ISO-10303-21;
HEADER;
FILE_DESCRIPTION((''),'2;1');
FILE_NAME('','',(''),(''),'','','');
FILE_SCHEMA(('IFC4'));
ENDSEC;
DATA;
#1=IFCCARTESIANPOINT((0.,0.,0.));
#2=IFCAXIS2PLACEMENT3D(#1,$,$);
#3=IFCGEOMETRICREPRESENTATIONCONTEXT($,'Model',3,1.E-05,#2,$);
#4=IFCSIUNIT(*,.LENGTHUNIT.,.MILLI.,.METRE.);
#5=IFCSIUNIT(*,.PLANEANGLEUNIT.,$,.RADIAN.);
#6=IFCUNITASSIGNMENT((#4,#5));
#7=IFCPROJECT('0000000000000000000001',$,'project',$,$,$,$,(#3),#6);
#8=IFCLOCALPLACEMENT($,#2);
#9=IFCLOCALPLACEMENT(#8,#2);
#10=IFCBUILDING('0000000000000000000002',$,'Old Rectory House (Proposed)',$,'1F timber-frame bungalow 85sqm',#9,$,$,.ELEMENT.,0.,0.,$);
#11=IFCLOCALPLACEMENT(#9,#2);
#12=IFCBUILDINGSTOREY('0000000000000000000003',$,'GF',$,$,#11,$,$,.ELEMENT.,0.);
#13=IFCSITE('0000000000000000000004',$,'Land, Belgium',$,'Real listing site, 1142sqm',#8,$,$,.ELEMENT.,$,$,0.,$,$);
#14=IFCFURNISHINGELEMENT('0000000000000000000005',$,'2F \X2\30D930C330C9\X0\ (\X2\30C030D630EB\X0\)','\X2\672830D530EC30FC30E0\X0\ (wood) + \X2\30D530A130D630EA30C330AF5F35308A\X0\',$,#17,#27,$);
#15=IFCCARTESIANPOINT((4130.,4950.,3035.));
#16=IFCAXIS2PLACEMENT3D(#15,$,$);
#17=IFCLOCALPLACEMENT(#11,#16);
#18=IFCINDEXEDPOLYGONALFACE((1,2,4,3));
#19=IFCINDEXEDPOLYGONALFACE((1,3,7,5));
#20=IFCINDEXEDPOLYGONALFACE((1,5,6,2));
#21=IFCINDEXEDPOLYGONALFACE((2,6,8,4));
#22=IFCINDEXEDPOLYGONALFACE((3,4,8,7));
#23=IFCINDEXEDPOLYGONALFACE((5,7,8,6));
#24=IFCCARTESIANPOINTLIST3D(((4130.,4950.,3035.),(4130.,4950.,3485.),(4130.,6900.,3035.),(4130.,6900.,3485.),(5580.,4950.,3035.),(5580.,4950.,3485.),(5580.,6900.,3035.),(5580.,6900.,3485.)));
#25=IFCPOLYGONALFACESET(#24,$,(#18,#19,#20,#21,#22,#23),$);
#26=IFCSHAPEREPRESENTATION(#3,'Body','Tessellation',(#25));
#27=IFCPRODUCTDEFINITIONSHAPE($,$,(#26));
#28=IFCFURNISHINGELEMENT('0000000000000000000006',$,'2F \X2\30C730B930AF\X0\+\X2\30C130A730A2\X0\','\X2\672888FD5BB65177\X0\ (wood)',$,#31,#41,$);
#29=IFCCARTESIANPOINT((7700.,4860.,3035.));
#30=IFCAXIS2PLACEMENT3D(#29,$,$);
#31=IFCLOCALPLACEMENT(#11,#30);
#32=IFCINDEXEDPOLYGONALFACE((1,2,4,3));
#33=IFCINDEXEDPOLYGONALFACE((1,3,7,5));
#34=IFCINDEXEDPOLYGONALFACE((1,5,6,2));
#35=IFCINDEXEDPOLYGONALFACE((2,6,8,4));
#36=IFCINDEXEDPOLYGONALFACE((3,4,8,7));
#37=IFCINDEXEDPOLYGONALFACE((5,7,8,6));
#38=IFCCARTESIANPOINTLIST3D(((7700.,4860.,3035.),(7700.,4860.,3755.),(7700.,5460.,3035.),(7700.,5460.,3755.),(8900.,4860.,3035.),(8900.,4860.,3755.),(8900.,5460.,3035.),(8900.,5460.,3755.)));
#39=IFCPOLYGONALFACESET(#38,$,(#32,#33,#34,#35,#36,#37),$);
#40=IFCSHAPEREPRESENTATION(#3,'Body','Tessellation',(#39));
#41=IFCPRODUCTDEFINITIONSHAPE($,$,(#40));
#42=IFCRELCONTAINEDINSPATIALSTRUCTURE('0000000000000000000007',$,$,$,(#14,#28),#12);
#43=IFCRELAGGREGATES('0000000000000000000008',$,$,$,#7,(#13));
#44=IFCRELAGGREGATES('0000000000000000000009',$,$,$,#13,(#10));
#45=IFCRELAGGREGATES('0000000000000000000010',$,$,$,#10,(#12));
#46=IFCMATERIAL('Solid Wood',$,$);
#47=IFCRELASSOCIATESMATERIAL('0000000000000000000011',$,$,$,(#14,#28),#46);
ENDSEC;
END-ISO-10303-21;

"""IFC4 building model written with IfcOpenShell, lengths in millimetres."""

from ifc_helpers import new_model, si_unit, frame, frame_2d, origin, place, context, project, spatial, rectangle, extrude, material, element, save


model = new_model("IFC4")

# Units and contexts
model_context = context("Model", 3, precision=1e-05, world=origin())
ifc_project = project(units=[si_unit("LENGTHUNIT", "METRE", prefix="MILLI"), si_unit("PLANEANGLEUNIT", "RADIAN")], contexts=[model_context])

# Site, building, storey
site_placement = place(None, origin())
site = spatial("IfcSite", under=ifc_project, at=site_placement, Name="Land, Belgium", ObjectType="Real listing site, 1142sqm", CompositionType="ELEMENT", RefElevation=0.0)
building_placement = place(site_placement, origin())
building = spatial("IfcBuilding", under=site, at=building_placement, Name="Old Rectory House (Proposed)", ObjectType="1F timber-frame bungalow 85sqm", CompositionType="ELEMENT", ElevationOfRefHeight=0.0, ElevationOfTerrain=0.0)
storey_placement = place(building_placement, origin())
storey = spatial("IfcBuildingStorey", under=building, at=storey_placement, Name="GF", CompositionType="ELEMENT", Elevation=0.0)

# Shared definitions
ifc_material_1 = material(Name="Solid Wood")

# Furnishing elements
furnishing_1_placement = place(storey_placement, frame((4130.0, 4950.0, 3035.0)))
element("IfcFurnishingElement", 1, at=furnishing_1_placement, inside=storey, material=ifc_material_1, Name="2F ベッド (ダブル)", Description="木フレーム (wood) + ファブリック張り", context=model_context, shape_type="SweptSolid", body=[
    extrude(rectangle(XDim=1450.0, YDim=1950.0, at=frame_2d((725.0, 975.0))), frame((4130.0, 4950.0, 3035.0)), (0.0, 0.0, 1.0), 450.0),
])
furnishing_2_placement = place(storey_placement, frame((7700.0, 4860.0, 3035.0)))
element("IfcFurnishingElement", 2, at=furnishing_2_placement, inside=storey, material=ifc_material_1, Name="2F デスク+チェア", Description="木製家具 (wood)", context=model_context, shape_type="SweptSolid", body=[
    extrude(rectangle(XDim=1200.0, YDim=600.0, at=frame_2d((600.0, 300.0))), frame((7700.0, 4860.0, 3035.0)), (0.0, 0.0, 1.0), 720.0),
])

save(model, "model.ifc")
